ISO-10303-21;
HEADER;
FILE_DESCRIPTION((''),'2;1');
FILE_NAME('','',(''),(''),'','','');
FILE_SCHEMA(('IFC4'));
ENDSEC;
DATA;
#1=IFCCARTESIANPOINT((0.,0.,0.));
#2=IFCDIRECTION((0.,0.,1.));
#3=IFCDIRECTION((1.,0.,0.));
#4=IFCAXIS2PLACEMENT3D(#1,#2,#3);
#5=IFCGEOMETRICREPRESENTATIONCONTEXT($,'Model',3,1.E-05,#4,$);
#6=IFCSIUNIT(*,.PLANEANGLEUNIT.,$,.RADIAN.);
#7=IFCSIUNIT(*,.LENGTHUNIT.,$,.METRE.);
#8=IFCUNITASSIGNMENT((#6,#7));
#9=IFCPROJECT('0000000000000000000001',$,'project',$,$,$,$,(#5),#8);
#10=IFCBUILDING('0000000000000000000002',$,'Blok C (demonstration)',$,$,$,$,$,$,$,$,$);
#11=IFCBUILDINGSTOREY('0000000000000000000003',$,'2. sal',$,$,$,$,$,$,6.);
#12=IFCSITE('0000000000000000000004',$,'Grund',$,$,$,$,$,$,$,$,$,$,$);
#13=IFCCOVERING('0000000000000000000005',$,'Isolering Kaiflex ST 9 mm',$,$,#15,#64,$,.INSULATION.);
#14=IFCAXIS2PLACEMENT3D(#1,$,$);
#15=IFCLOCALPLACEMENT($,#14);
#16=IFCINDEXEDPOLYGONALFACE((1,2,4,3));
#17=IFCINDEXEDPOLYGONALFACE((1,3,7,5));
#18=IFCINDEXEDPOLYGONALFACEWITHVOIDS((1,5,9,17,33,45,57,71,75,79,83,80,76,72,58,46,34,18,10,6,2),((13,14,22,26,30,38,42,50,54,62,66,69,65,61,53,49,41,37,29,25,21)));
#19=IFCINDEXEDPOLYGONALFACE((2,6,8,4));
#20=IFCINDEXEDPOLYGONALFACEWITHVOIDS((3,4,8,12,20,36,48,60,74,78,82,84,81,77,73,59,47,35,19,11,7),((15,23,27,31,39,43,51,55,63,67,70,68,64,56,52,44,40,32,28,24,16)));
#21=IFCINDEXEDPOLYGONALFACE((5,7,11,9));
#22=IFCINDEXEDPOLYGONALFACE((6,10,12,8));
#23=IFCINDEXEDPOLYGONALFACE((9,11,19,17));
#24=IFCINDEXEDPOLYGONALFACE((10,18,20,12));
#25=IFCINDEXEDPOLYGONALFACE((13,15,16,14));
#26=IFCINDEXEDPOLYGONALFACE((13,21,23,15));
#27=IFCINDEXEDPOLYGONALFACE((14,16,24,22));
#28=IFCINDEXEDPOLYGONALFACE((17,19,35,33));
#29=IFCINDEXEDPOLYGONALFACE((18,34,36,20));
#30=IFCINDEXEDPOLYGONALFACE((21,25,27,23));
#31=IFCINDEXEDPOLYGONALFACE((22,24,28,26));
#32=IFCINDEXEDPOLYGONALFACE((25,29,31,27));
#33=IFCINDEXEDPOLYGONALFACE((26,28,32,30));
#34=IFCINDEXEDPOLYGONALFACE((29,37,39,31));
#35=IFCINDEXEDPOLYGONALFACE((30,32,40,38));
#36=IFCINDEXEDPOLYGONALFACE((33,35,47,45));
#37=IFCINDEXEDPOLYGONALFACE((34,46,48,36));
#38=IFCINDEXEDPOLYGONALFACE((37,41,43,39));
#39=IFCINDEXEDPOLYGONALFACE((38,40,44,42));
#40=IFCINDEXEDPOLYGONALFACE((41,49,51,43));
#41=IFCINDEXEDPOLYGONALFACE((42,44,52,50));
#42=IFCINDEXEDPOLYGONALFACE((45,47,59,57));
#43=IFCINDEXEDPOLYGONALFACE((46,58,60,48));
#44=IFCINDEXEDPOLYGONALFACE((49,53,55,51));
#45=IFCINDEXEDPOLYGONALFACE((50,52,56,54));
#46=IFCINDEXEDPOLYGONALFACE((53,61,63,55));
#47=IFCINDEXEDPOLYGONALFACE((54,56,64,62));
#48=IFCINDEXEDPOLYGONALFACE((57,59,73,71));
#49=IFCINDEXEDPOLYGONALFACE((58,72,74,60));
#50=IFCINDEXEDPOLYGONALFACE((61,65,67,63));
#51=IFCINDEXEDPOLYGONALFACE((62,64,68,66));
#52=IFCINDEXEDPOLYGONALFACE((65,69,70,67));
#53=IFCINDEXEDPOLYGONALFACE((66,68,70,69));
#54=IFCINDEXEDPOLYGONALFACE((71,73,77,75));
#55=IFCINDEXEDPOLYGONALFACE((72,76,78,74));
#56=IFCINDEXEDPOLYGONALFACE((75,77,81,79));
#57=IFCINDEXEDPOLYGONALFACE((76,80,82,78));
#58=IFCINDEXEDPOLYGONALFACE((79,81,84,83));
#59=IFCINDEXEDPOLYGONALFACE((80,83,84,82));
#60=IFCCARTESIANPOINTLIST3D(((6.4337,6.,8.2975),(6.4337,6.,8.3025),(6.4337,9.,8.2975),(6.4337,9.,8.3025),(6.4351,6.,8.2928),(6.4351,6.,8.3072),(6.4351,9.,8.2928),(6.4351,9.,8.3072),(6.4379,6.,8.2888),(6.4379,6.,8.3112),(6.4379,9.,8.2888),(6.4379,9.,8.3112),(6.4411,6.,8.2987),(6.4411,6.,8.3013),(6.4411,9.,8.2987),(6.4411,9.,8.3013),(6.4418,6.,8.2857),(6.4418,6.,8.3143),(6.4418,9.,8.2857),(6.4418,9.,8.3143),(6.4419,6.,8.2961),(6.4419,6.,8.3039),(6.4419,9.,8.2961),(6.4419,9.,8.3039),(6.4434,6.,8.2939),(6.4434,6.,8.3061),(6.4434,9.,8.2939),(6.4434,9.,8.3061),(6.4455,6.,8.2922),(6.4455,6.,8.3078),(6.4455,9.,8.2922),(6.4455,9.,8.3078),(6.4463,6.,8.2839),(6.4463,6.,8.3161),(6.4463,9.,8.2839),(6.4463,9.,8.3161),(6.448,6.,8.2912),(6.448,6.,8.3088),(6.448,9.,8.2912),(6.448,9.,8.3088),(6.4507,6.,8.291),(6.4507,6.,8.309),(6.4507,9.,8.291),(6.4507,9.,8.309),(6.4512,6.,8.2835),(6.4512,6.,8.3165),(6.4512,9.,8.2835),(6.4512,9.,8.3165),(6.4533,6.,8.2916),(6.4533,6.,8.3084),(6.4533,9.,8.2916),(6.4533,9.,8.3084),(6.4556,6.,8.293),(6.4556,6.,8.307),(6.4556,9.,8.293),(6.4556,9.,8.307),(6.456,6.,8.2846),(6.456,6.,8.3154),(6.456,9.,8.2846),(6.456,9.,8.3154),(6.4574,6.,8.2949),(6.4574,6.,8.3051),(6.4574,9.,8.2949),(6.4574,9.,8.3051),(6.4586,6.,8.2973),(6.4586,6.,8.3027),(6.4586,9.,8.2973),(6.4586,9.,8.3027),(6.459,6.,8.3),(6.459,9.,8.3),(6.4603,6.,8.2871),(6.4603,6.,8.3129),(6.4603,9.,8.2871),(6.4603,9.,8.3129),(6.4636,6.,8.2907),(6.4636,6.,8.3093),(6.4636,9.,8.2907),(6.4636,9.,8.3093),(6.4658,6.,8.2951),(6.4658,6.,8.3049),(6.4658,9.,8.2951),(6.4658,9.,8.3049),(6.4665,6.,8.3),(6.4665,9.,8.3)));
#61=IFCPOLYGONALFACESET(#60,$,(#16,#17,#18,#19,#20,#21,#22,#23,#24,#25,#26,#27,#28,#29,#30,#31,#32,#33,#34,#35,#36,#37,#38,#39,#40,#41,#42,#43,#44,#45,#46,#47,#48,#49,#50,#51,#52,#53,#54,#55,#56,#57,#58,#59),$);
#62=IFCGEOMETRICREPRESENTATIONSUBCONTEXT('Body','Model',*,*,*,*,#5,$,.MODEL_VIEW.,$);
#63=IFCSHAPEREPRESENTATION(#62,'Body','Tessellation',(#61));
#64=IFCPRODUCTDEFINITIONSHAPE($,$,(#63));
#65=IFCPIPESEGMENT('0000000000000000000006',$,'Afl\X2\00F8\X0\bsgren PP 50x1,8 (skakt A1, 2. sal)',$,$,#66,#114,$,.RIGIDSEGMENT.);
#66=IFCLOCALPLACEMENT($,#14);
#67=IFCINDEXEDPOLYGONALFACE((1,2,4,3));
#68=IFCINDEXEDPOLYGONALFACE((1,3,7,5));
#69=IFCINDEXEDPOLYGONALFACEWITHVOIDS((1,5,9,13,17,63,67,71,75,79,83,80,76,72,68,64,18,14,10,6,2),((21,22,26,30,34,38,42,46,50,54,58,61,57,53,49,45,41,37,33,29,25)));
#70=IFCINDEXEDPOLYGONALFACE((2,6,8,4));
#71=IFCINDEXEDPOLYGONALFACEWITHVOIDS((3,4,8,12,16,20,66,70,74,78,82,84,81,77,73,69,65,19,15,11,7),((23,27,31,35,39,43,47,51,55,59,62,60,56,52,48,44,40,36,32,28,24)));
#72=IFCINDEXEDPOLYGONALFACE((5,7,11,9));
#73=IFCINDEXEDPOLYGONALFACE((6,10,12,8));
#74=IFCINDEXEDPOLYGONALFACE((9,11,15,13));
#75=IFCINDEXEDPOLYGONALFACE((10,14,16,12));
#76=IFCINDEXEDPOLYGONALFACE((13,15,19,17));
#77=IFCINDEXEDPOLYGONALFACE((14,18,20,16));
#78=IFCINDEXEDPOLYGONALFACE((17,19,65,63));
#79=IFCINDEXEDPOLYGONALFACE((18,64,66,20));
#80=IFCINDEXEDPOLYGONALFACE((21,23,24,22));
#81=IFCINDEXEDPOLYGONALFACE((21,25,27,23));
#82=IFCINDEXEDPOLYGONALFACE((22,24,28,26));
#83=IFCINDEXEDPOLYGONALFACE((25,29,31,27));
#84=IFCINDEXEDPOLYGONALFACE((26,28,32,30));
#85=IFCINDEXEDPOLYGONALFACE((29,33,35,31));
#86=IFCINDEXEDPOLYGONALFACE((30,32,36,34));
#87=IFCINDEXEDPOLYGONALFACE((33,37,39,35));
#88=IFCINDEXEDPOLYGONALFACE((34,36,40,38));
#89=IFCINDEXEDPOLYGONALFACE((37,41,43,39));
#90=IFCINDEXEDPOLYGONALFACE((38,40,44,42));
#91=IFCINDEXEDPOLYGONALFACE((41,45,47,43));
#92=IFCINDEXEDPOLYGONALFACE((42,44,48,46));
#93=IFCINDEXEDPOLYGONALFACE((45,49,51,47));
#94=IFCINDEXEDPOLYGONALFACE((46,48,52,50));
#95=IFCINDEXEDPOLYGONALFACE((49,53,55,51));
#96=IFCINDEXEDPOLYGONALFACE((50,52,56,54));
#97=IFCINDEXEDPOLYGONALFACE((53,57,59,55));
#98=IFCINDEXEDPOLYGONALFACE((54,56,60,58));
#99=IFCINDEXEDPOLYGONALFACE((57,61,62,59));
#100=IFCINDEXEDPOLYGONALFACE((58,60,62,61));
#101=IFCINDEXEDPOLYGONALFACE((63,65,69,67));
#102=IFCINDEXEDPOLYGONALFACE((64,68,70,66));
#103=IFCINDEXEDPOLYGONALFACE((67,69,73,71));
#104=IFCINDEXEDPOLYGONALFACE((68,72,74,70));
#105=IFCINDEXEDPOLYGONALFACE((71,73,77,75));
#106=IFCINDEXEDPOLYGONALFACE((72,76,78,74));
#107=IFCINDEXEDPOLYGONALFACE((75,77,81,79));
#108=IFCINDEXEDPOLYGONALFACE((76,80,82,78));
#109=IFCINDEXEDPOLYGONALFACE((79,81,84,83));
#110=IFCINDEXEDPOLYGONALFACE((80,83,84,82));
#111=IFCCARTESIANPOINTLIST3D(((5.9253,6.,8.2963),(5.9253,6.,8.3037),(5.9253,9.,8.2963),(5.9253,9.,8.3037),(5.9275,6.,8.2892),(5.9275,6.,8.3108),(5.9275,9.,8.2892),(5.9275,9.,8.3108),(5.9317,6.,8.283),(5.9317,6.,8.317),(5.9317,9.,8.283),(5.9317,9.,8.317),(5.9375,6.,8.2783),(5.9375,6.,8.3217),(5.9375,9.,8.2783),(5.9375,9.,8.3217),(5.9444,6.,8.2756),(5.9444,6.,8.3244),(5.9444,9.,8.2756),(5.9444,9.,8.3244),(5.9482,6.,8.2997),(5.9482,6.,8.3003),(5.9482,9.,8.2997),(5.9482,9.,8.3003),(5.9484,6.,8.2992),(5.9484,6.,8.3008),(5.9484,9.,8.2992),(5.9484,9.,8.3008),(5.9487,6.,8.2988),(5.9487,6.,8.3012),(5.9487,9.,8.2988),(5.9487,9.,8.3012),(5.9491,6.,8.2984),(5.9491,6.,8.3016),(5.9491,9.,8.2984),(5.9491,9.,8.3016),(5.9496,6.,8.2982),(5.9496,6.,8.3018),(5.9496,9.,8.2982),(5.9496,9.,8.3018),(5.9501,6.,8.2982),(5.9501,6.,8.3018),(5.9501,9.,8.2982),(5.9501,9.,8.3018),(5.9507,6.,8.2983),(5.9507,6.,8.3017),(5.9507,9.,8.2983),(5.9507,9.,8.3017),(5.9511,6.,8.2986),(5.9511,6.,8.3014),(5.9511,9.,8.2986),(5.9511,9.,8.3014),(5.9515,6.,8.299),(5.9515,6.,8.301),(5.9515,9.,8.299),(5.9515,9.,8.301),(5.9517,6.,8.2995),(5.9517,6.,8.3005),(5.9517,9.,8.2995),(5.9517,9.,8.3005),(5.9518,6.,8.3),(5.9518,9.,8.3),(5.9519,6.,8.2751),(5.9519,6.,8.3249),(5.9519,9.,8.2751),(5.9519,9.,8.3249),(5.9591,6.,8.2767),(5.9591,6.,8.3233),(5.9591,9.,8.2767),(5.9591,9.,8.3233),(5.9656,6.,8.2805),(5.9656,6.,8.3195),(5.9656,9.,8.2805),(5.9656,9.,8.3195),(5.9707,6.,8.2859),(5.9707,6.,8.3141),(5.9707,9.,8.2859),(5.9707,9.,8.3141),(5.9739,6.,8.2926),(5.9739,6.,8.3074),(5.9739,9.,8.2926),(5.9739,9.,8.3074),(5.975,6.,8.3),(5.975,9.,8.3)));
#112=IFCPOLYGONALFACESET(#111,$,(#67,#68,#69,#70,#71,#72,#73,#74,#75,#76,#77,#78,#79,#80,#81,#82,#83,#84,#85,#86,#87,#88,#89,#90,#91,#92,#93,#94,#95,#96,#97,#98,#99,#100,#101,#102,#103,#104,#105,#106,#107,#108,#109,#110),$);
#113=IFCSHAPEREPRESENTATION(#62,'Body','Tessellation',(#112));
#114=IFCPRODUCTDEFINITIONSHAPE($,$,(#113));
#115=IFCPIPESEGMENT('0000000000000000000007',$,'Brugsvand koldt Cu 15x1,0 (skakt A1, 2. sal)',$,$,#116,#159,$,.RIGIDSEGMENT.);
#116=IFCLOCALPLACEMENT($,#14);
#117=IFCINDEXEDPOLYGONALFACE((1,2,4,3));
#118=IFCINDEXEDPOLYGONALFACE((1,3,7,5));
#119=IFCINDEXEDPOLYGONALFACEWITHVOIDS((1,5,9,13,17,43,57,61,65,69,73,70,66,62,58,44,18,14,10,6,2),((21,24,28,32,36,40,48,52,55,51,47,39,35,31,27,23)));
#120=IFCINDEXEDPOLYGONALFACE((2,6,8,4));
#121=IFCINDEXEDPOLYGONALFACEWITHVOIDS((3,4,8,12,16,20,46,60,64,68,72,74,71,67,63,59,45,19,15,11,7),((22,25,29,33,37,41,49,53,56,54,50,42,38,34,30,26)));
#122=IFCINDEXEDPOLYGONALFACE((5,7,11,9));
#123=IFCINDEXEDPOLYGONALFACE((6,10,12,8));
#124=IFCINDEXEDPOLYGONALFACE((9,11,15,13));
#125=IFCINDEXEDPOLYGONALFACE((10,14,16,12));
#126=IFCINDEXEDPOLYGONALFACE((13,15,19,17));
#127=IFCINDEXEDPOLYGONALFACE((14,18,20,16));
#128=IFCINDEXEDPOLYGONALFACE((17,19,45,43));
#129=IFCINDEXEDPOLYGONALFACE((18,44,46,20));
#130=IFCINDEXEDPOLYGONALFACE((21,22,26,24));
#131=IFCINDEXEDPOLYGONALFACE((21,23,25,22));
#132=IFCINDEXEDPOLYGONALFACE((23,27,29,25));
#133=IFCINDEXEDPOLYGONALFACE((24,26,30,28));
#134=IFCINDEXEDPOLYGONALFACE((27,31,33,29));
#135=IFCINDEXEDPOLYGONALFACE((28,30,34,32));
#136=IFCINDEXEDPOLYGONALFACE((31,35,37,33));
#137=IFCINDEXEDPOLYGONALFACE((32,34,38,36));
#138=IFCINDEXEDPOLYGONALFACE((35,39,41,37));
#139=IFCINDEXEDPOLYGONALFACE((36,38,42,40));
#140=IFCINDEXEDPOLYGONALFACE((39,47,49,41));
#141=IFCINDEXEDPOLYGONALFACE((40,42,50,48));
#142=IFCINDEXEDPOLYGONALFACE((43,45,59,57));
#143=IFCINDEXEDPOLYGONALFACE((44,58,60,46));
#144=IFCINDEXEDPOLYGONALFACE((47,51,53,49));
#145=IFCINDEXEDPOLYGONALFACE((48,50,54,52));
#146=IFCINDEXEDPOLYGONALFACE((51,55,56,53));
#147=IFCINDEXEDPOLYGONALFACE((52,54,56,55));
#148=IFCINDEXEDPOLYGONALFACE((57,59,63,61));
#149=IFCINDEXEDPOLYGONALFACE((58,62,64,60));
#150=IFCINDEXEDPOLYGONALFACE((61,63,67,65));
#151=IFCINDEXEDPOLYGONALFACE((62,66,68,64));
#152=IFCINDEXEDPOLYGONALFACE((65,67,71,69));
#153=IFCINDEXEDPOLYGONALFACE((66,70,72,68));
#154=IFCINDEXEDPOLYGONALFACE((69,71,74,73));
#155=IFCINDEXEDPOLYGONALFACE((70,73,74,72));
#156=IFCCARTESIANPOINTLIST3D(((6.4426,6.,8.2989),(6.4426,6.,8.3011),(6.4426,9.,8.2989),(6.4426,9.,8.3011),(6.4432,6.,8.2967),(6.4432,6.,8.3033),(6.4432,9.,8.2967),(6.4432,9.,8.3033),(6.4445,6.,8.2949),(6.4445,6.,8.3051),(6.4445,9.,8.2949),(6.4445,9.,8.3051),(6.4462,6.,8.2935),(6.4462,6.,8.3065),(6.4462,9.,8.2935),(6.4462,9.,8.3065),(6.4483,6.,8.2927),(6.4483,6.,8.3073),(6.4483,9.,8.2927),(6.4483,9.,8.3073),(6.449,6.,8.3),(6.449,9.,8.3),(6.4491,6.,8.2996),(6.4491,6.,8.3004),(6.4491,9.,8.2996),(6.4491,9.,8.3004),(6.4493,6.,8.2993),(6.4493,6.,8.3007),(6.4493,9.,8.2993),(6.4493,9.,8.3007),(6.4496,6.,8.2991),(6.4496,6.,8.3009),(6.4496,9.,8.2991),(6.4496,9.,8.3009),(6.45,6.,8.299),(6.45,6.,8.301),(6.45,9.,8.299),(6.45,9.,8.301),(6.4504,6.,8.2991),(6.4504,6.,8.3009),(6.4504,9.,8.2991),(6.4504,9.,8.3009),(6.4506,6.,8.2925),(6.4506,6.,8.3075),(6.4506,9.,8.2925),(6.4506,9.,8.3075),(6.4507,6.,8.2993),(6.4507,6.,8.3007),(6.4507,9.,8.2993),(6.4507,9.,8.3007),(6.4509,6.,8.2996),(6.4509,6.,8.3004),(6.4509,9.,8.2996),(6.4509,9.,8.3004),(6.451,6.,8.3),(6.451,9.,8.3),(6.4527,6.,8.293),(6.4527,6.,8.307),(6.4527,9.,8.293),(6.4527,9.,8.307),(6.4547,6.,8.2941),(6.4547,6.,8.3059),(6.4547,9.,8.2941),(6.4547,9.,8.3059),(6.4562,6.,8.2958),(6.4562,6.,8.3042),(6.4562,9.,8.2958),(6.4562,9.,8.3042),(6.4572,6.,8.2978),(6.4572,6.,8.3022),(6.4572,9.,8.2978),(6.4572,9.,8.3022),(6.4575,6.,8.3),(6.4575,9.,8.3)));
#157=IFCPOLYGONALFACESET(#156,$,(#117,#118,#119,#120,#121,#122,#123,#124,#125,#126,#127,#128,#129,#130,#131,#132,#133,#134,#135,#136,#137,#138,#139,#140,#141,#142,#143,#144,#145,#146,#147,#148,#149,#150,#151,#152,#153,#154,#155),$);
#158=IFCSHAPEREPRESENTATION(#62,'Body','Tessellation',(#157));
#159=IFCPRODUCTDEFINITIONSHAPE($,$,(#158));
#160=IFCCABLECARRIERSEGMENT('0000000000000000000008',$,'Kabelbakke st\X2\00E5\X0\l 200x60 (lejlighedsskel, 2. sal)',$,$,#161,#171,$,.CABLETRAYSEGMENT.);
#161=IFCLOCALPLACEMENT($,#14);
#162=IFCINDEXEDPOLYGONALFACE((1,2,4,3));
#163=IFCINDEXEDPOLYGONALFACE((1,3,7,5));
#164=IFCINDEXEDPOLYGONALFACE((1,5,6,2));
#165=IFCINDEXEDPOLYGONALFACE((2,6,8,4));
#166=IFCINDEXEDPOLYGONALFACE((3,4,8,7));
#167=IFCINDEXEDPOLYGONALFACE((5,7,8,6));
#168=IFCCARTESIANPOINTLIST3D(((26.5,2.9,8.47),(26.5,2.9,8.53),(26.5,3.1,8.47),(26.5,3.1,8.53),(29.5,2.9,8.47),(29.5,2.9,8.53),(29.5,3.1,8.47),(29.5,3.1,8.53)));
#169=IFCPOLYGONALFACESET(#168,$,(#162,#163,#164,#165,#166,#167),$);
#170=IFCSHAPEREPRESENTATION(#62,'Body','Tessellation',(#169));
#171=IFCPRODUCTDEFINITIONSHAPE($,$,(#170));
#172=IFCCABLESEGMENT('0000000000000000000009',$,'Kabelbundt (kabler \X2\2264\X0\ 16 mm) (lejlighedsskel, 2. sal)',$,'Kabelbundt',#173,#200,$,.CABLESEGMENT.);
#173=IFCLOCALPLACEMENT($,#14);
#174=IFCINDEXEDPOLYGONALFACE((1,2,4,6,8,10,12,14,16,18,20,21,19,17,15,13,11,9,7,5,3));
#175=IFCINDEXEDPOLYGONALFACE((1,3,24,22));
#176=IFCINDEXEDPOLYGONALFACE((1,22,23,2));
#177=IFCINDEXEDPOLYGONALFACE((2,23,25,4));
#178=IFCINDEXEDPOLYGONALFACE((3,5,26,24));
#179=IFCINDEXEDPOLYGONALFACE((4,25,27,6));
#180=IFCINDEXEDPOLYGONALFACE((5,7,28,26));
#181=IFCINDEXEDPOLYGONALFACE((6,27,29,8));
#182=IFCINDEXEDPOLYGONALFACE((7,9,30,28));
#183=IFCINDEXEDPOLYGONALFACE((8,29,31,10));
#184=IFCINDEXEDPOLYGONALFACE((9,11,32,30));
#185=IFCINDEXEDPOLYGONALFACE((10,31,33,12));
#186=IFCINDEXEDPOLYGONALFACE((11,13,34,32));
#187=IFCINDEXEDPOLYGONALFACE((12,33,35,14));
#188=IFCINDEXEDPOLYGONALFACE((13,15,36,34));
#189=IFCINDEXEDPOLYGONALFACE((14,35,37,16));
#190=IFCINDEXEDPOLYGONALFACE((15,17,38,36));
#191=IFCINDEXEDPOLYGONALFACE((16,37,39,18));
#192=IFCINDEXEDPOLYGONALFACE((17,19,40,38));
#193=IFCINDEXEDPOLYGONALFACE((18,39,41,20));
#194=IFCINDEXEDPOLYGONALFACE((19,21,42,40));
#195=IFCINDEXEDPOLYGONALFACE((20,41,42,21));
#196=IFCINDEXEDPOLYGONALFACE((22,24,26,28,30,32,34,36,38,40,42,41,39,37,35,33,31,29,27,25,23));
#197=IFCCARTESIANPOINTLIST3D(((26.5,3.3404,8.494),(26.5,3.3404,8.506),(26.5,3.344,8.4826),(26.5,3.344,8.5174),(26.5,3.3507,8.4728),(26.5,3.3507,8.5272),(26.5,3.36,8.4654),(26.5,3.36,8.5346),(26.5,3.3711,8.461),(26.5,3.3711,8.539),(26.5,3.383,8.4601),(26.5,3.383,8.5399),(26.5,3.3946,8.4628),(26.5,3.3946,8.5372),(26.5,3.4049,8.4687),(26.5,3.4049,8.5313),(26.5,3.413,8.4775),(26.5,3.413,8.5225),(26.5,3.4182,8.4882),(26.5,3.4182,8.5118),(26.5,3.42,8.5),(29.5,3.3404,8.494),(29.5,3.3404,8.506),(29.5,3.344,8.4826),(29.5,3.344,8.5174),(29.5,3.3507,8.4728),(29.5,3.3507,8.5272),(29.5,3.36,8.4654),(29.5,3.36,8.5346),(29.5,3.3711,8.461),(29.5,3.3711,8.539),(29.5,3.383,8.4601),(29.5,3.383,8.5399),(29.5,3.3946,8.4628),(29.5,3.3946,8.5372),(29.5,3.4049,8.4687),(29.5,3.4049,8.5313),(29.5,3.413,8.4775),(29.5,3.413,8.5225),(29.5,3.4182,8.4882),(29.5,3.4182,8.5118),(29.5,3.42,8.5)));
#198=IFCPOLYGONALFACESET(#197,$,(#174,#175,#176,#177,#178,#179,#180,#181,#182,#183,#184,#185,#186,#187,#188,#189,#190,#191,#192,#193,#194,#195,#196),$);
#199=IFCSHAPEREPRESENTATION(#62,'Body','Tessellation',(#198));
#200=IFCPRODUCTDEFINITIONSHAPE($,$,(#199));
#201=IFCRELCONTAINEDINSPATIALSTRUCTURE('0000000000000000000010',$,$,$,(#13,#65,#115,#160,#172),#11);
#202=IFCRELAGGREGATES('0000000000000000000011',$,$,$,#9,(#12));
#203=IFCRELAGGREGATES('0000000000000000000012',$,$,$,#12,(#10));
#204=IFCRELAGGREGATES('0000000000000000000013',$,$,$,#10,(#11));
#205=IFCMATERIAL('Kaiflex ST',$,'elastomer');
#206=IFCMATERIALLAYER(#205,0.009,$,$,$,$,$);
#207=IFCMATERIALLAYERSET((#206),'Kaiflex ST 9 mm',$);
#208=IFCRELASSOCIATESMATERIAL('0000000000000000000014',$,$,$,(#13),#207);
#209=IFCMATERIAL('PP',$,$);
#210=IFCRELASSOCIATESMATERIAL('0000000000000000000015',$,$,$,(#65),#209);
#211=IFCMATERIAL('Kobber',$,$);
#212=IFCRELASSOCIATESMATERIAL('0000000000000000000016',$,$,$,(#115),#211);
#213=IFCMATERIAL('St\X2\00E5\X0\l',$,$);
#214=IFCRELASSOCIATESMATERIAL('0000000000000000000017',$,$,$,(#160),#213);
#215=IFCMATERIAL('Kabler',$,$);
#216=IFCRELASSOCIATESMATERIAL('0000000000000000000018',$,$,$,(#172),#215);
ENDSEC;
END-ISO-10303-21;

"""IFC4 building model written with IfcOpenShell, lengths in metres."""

from ifc_helpers import new_model, si_unit, frame, origin_with_axes, place, context, subcontext, project, spatial, polyline, circle, hollow_circle, outline, extrude, material, layer, layer_set, element, save


model = new_model("IFC4")

# Units and contexts
model_context = context("Model", 3, precision=1e-05, world=origin_with_axes())
body_context = subcontext(model_context, "Body", "Model", "MODEL_VIEW")
ifc_project = project(units=[si_unit("PLANEANGLEUNIT", "RADIAN"), si_unit("LENGTHUNIT", "METRE")], contexts=[model_context])

# Site, building, storey
site = spatial("IfcSite", under=ifc_project, Name="Grund")
building = spatial("IfcBuilding", under=site, Name="Blok C (demonstration)")
storey = spatial("IfcBuildingStorey", under=building, Name="2. sal", Elevation=6.0)

# Covering
ifc_material_1 = material(Name="Kaiflex ST", Category="elastomer")
ifc_layer = layer(ifc_material_1, 0.009)
ifc_layer_set = layer_set([ifc_layer], Name="Kaiflex ST 9 mm")
covering_placement = place(None, origin_with_axes())
element("IfcCovering", 1, at=covering_placement, inside=storey, material=ifc_layer_set, Name="Isolering Kaiflex ST 9 mm", PredefinedType="INSULATION", context=body_context, shape_type="SweptSolid", body=[
    extrude(hollow_circle(Radius=0.0165, WallThickness=0.0075), frame((6.45, 6.0, 8.3), z_axis=(0.0, 1.0, 0.0), x_axis=(1.0, 0.0, 0.0)), (0.0, 0.0, 1.0), 3.0),
])

# Pipe segments
ifc_material_2 = material(Name="PP")
pipe_segment_1_placement = place(None, origin_with_axes())
element("IfcPipeSegment", 2, at=pipe_segment_1_placement, inside=storey, material=ifc_material_2, Name="Afløbsgren PP 50x1,8 (skakt A1, 2. sal)", PredefinedType="RIGIDSEGMENT", context=body_context, shape_type="SweptSolid", body=[
    extrude(hollow_circle(Radius=0.025, WallThickness=0.0232), frame((5.95, 6.0, 8.3), z_axis=(0.0, 1.0, 0.0), x_axis=(1.0, 0.0, 0.0)), (0.0, 0.0, 1.0), 3.0),
])
ifc_material_3 = material(Name="Kobber")
pipe_segment_2_placement = place(None, origin_with_axes())
element("IfcPipeSegment", 3, at=pipe_segment_2_placement, inside=storey, material=ifc_material_3, Name="Brugsvand koldt Cu 15x1,0 (skakt A1, 2. sal)", PredefinedType="RIGIDSEGMENT", context=body_context, shape_type="SweptSolid", body=[
    extrude(hollow_circle(Radius=0.0075, WallThickness=0.0065), frame((6.45, 6.0, 8.3), z_axis=(0.0, 1.0, 0.0), x_axis=(1.0, 0.0, 0.0)), (0.0, 0.0, 1.0), 3.0),
])

# Cable carrier segment
ifc_material_4 = material(Name="Stål")
cable_carrier_segment_placement = place(None, origin_with_axes())
element("IfcCableCarrierSegment", 4, at=cable_carrier_segment_placement, inside=storey, material=ifc_material_4, Name="Kabelbakke stål 200x60 (lejlighedsskel, 2. sal)", PredefinedType="CABLETRAYSEGMENT", context=body_context, shape_type="SweptSolid", body=[
    extrude(outline(polyline([(26.5, 2.9), (29.5, 2.9), (29.5, 3.1), (26.5, 3.1), (26.5, 2.9)])), frame((0.0, 0.0, 8.47)), (0.0, 0.0, 1.0), 0.06),
])

# Cable segment
ifc_material_5 = material(Name="Kabler")
cable_segment_placement = place(None, origin_with_axes())
element("IfcCableSegment", 5, at=cable_segment_placement, inside=storey, material=ifc_material_5, Name="Kabelbundt (kabler ≤ 16 mm) (lejlighedsskel, 2. sal)", ObjectType="Kabelbundt", PredefinedType="CABLESEGMENT", context=body_context, shape_type="SweptSolid", body=[
    extrude(circle(Radius=0.04), frame((26.5, 3.38, 8.5), z_axis=(1.0, 0.0, 0.0), x_axis=(0.0, 1.0, 0.0)), (0.0, 0.0, 1.0), 3.0),
])

save(model, "model.ifc")
